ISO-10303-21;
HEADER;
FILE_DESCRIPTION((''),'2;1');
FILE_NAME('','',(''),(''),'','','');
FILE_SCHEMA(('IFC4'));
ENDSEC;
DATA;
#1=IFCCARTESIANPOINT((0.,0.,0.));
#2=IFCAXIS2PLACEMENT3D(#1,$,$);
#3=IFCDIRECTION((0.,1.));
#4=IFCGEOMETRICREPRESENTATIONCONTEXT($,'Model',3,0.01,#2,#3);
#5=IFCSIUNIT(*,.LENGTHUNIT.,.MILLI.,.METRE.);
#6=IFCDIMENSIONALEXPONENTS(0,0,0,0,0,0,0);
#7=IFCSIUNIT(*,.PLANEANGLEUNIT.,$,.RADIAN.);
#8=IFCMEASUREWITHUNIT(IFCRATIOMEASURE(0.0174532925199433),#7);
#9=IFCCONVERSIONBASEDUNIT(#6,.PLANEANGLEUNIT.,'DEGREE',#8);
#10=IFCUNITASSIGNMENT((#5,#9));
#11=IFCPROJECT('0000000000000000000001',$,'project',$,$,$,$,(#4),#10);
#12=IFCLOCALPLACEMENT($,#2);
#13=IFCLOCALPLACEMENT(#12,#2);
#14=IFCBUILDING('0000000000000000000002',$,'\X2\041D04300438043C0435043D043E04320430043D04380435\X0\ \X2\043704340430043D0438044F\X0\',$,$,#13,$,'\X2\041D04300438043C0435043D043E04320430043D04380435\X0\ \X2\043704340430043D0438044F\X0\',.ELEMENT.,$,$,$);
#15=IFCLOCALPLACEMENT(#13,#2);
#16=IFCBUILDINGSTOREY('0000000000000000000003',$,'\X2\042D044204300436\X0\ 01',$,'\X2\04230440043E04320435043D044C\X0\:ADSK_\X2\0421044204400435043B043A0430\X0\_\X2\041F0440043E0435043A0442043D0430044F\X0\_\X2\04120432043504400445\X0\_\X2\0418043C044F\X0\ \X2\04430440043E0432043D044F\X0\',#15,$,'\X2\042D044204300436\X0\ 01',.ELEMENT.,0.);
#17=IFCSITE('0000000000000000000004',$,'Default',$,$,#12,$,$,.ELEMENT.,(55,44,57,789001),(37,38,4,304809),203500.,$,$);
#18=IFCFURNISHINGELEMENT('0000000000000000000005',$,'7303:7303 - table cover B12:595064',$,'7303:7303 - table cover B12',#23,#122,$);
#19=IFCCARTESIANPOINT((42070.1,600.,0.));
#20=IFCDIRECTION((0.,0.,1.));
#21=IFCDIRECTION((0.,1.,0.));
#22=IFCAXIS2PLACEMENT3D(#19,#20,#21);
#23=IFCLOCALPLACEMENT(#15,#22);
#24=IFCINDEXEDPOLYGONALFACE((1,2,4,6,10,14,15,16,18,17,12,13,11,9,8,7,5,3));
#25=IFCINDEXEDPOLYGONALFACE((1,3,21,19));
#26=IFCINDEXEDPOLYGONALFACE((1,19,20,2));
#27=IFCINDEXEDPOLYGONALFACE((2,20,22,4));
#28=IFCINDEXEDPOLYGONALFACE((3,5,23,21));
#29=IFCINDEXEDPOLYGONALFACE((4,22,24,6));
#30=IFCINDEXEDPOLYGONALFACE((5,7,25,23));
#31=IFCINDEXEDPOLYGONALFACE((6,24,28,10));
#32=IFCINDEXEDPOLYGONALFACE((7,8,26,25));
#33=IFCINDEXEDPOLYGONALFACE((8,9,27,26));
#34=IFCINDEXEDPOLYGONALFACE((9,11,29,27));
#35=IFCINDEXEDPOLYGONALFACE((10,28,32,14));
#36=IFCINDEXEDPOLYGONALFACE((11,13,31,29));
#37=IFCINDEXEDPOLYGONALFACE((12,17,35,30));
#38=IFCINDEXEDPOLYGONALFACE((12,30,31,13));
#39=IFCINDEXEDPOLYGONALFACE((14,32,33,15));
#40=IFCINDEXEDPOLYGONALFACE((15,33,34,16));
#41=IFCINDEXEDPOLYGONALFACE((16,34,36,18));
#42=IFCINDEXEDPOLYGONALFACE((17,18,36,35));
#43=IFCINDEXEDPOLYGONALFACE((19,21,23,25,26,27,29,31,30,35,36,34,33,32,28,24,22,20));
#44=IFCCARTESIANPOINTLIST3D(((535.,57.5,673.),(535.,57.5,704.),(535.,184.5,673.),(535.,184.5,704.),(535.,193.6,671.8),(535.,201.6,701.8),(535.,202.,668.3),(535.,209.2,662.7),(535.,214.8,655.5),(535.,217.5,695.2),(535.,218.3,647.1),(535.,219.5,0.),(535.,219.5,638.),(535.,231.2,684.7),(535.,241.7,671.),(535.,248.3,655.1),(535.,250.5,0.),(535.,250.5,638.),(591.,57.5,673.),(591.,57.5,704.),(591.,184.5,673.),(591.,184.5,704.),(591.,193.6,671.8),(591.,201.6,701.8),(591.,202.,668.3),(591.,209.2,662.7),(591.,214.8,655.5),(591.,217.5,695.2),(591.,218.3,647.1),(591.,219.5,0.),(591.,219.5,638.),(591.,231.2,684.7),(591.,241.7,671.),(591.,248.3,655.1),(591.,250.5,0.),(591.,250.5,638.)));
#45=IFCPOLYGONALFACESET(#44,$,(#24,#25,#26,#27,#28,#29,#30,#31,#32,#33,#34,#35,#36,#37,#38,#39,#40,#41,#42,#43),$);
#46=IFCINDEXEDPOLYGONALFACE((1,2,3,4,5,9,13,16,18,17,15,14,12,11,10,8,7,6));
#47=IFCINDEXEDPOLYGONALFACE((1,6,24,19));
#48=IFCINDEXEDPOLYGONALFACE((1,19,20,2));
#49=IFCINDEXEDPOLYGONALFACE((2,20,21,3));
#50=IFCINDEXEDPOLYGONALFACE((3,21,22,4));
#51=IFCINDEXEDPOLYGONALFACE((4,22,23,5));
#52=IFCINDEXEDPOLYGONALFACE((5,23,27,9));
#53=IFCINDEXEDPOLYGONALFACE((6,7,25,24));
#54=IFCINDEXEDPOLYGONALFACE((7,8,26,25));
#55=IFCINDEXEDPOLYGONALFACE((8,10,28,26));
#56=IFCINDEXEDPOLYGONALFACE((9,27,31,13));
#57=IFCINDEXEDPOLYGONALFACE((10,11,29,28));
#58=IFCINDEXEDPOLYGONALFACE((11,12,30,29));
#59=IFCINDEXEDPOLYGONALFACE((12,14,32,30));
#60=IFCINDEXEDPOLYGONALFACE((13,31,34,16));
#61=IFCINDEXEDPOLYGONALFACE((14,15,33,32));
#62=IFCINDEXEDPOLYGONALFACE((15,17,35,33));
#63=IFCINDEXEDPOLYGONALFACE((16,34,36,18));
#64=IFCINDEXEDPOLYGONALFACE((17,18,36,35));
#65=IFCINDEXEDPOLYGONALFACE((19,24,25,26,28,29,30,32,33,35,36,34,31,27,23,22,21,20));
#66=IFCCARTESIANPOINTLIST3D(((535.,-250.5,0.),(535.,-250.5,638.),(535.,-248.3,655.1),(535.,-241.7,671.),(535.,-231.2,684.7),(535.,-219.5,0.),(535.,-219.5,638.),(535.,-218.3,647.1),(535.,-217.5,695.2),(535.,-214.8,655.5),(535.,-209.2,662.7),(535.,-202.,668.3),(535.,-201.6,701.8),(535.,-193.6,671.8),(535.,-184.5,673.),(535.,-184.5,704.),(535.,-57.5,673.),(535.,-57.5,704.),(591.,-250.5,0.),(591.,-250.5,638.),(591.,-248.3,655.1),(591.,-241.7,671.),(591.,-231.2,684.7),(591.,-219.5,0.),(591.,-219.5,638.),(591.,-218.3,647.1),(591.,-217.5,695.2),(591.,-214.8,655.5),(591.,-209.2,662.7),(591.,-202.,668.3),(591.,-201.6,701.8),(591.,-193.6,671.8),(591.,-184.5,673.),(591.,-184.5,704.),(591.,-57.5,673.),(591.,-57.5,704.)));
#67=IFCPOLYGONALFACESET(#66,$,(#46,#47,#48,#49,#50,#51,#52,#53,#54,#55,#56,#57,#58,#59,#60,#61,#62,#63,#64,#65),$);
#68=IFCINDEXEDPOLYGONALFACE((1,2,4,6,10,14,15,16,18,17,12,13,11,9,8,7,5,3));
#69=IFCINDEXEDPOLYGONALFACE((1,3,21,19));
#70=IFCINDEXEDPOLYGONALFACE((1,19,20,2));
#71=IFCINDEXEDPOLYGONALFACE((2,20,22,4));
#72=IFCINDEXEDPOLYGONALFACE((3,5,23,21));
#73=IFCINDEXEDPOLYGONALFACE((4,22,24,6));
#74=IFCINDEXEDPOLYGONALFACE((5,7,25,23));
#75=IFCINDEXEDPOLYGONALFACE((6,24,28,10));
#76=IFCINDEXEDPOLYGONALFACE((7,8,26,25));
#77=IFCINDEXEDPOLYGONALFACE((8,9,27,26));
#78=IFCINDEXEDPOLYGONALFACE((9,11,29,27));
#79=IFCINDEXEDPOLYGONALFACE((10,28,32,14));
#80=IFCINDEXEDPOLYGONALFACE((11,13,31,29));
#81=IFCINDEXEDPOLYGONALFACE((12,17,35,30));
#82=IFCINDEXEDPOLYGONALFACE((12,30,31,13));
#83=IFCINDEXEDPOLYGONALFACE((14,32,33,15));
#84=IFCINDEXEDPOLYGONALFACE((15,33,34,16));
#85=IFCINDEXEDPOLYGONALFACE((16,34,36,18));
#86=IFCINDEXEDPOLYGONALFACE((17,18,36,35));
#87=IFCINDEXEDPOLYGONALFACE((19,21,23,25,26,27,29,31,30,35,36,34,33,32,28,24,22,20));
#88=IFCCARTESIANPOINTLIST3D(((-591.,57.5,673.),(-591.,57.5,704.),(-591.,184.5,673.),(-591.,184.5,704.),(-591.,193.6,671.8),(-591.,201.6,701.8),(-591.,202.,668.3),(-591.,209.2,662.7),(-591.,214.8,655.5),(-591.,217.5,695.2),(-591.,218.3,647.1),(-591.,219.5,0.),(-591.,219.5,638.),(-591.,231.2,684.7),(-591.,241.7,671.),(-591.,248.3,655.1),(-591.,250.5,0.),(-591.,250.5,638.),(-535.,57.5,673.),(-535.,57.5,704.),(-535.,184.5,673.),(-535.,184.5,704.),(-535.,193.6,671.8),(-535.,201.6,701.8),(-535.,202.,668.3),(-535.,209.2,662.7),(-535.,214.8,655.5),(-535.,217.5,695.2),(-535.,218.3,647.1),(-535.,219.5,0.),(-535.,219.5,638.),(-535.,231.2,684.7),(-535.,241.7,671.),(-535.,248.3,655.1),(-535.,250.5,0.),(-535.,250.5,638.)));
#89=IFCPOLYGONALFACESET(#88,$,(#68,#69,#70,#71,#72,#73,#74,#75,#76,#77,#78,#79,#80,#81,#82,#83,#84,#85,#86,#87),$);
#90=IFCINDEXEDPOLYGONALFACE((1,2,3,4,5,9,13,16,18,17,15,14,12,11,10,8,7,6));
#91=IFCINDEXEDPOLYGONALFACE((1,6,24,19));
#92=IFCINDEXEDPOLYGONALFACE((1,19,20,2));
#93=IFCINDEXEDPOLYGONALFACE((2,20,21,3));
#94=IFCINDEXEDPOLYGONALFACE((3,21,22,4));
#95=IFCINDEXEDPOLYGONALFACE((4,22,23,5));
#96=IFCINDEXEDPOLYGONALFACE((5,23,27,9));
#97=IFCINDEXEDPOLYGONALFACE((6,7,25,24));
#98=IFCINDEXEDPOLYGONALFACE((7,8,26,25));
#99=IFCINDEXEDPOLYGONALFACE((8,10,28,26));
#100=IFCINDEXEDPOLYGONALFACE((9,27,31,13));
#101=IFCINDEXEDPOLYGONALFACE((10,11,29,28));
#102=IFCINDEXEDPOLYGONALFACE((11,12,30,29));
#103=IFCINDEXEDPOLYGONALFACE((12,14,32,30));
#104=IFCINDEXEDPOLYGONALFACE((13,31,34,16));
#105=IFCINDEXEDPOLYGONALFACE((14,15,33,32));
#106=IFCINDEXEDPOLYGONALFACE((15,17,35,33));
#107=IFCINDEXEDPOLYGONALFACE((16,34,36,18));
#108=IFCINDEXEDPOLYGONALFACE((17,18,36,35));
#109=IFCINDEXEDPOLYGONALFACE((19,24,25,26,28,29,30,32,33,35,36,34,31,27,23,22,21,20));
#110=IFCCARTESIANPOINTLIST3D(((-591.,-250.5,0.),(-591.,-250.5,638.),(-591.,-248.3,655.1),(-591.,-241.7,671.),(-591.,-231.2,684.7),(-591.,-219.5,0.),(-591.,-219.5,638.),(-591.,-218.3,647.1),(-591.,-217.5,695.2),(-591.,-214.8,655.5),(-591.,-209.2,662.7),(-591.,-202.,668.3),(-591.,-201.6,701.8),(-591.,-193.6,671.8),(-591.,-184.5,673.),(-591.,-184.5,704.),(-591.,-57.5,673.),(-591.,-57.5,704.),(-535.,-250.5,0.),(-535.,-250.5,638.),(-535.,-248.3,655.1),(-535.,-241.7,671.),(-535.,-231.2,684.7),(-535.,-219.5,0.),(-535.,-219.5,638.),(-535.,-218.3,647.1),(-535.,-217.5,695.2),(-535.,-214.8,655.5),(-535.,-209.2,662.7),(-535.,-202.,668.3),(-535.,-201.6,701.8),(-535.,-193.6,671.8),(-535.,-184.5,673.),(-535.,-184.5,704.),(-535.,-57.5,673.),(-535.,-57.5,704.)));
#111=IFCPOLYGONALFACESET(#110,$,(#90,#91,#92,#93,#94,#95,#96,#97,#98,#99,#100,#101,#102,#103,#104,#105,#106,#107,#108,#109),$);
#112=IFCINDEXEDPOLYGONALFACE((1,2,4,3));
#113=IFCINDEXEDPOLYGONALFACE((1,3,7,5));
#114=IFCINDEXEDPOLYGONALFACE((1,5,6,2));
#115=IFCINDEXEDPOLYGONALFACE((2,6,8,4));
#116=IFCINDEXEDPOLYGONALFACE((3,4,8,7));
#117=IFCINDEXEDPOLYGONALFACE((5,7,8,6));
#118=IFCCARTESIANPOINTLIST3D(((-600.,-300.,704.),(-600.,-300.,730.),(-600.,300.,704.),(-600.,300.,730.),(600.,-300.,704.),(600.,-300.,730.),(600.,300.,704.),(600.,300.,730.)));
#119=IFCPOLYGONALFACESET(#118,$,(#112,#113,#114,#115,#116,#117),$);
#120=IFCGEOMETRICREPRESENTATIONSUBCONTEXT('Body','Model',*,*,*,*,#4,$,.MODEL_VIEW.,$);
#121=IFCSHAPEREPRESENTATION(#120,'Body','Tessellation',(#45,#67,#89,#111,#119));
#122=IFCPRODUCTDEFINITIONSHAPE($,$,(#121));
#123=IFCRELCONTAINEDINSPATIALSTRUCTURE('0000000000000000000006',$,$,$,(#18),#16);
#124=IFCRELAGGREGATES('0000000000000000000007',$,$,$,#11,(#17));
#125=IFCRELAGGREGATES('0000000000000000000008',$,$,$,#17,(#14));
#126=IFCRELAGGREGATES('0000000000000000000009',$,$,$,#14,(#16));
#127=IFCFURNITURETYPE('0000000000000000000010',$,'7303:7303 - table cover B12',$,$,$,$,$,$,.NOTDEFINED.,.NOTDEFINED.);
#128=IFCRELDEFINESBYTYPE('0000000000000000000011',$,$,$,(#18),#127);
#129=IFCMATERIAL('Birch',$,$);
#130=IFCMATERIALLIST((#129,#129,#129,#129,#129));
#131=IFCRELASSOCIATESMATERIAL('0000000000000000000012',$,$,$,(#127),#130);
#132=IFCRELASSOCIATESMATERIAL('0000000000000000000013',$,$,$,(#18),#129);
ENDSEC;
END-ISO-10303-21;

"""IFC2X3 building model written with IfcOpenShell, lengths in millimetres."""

from ifc_helpers import new_model, entity, si_unit, converted_unit, direction, frame, frame_2d, origin, origin_2d_with_axis, place, context, subcontext, project, spatial, polyline, circle_curve, parameter, trimmed, segment, composite_curve, rectangle, outline, extrude, source, transform, mapped, material, material_list, type_object, type_shapes, element, save


model = new_model("IFC2X3")

# Units and contexts
model_context = context("Model", 3, precision=0.01, world=origin(), true_north=direction((0.0, 1.0)))
body_context = subcontext(model_context, "Body", "Model", "MODEL_VIEW")
ifc_project = project(units=[si_unit("LENGTHUNIT", "METRE", prefix="MILLI"), converted_unit("PLANEANGLEUNIT", "DEGREE", entity("IfcRatioMeasure", 0.0174532925199433), si_unit("PLANEANGLEUNIT", "RADIAN"), dimensions=[0, 0, 0, 0, 0, 0, 0])], contexts=[model_context])

# Site, building, storey
site_placement = place(None, origin())
site = spatial("IfcSite", under=ifc_project, at=site_placement, Name="Default", CompositionType="ELEMENT", RefLatitude=(55, 44, 57, 789001), RefLongitude=(37, 38, 4, 304809), RefElevation=203500.0)
building_placement = place(site_placement, origin())
building = spatial("IfcBuilding", under=site, at=building_placement, Name="Наименование здания", LongName="Наименование здания", CompositionType="ELEMENT")
storey_placement = place(building_placement, origin())
storey = spatial("IfcBuildingStorey", under=building, at=storey_placement, Name="Этаж 01", ObjectType="Уровень:ADSK_Стрелка_Проектная_Вверх_Имя уровня", LongName="Этаж 01", CompositionType="ELEMENT", Elevation=0.0)

# Furnishing element
ifc_material_1 = material(Name="Birch")
ifc_material_list_1 = material_list([ifc_material_1, ifc_material_1, ifc_material_1, ifc_material_1, ifc_material_1])
furniture_type = type_object("IfcFurnitureType", Name="7303:7303 - table cover B12", material=ifc_material_list_1)
shared_shape_1 = source(origin(), body_context, "Body", "SweptSolid", [
    extrude(outline(composite_curve([segment(polyline([(-200.2, -120.5), (-169.2, -120.5)]), True, "CONTINUOUS"), segment(polyline([(-169.2, -120.5), (-169.2, 6.5)]), True, "CONTINUOUS"), segment(trimmed(circle_curve(frame_2d((-134.2, 6.5), x_axis=(0.0, -1.0)), 35.0), [parameter(180.0)], [parameter(270.0)], True, "PARAMETER"), False, "CONTINUOUS"), segment(polyline([(-134.2, 41.5), (503.8, 41.5)]), True, "CONTINUOUS"), segment(polyline([(503.8, 41.5), (503.8, 72.5)]), True, "CONTINUOUS"), segment(polyline([(503.8, 72.5), (-134.2, 72.5)]), True, "CONTINUOUS"), segment(trimmed(circle_curve(frame_2d((-134.2, 6.5), x_axis=(0.0, -1.0)), 66.0), [parameter(180.0)], [parameter(270.0)], True, "PARAMETER"), True, "CONTINUOUS"), segment(polyline([(-200.2, 6.5), (-200.2, -120.5)]), True, "CONTINUOUS")], self_intersect=False)), frame((535.0, 178.0, 503.8), z_axis=(1.0, 0.0, 0.0), x_axis=(0.0, 0.0, -1.0)), (0.0, 0.0, 1.0), 56.0),
    extrude(outline(composite_curve([segment(polyline([(-120.5, -200.2), (6.5, -200.2)]), True, "CONTINUOUS"), segment(trimmed(circle_curve(frame_2d((6.5, -134.2), x_axis=(-1.0, 0.0)), 66.0), [parameter(90.0)], [parameter(180.0)], True, "PARAMETER"), True, "CONTINUOUS"), segment(polyline([(72.5, -134.2), (72.5, 503.8)]), True, "CONTINUOUS"), segment(polyline([(72.5, 503.8), (41.5, 503.8)]), True, "CONTINUOUS"), segment(polyline([(41.5, 503.8), (41.5, -134.2)]), True, "CONTINUOUS"), segment(trimmed(circle_curve(frame_2d((6.5, -134.2), x_axis=(-1.0, 0.0)), 35.0), [parameter(90.0)], [parameter(180.0)], True, "PARAMETER"), False, "CONTINUOUS"), segment(polyline([(6.5, -169.2), (-120.5, -169.2)]), True, "CONTINUOUS"), segment(polyline([(-120.5, -169.2), (-120.5, -200.2)]), True, "CONTINUOUS")], self_intersect=False)), frame((535.0, -178.0, 503.8), z_axis=(1.0, 0.0, 0.0), x_axis=(0.0, -1.0, 0.0)), (0.0, 0.0, 1.0), 56.0),
    extrude(outline(composite_curve([segment(polyline([(-200.2, -120.5), (-169.2, -120.5)]), True, "CONTINUOUS"), segment(polyline([(-169.2, -120.5), (-169.2, 6.5)]), True, "CONTINUOUS"), segment(trimmed(circle_curve(frame_2d((-134.2, 6.5), x_axis=(0.0, -1.0)), 35.0), [parameter(180.0)], [parameter(270.0)], True, "PARAMETER"), False, "CONTINUOUS"), segment(polyline([(-134.2, 41.5), (503.8, 41.5)]), True, "CONTINUOUS"), segment(polyline([(503.8, 41.5), (503.8, 72.5)]), True, "CONTINUOUS"), segment(polyline([(503.8, 72.5), (-134.2, 72.5)]), True, "CONTINUOUS"), segment(trimmed(circle_curve(frame_2d((-134.2, 6.5), x_axis=(0.0, -1.0)), 66.0), [parameter(180.0)], [parameter(270.0)], True, "PARAMETER"), True, "CONTINUOUS"), segment(polyline([(-200.2, 6.5), (-200.2, -120.5)]), True, "CONTINUOUS")], self_intersect=False)), frame((-591.0, 178.0, 503.8), z_axis=(1.0, 0.0, 0.0), x_axis=(0.0, 0.0, -1.0)), (0.0, 0.0, 1.0), 56.0),
    extrude(outline(composite_curve([segment(polyline([(-120.5, -200.2), (6.5, -200.2)]), True, "CONTINUOUS"), segment(trimmed(circle_curve(frame_2d((6.5, -134.2), x_axis=(-1.0, 0.0)), 66.0), [parameter(90.0)], [parameter(180.0)], True, "PARAMETER"), True, "CONTINUOUS"), segment(polyline([(72.5, -134.2), (72.5, 503.8)]), True, "CONTINUOUS"), segment(polyline([(72.5, 503.8), (41.5, 503.8)]), True, "CONTINUOUS"), segment(polyline([(41.5, 503.8), (41.5, -134.2)]), True, "CONTINUOUS"), segment(trimmed(circle_curve(frame_2d((6.5, -134.2), x_axis=(-1.0, 0.0)), 35.0), [parameter(90.0)], [parameter(180.0)], True, "PARAMETER"), False, "CONTINUOUS"), segment(polyline([(6.5, -169.2), (-120.5, -169.2)]), True, "CONTINUOUS"), segment(polyline([(-120.5, -169.2), (-120.5, -200.2)]), True, "CONTINUOUS")], self_intersect=False)), frame((-591.0, -178.0, 503.8), z_axis=(1.0, 0.0, 0.0), x_axis=(0.0, -1.0, 0.0)), (0.0, 0.0, 1.0), 56.0),
    extrude(rectangle(XDim=1200.0, YDim=600.0, at=origin_2d_with_axis()), frame((0.0, 0.0, 704.0), z_axis=(0.0, 0.0, 1.0), x_axis=(-1.0, 0.0, 0.0)), (0.0, 0.0, 1.0), 26.0),
])
type_shapes(furniture_type, [shared_shape_1])
for number, where, z_axis, x_axis, name in (
    (1, (42070.1, 600.0, 0.0), (0.0, 0.0, 1.0), (0.0, 1.0, 0.0), "7303:7303 - table cover B12:595064"),
):
    element("IfcFurnishingElement", number, at=place(storey_placement, frame(where, z_axis=z_axis, x_axis=x_axis)), inside=storey, type_object=furniture_type, material=ifc_material_1, Name=name, ObjectType="7303:7303 - table cover B12", context=body_context, shape_type="MappedRepresentation", body=[
        mapped(shared_shape_1, transform((0.0, 0.0, 0.0), scale=1.0)),
    ])

save(model, "model.ifc")
